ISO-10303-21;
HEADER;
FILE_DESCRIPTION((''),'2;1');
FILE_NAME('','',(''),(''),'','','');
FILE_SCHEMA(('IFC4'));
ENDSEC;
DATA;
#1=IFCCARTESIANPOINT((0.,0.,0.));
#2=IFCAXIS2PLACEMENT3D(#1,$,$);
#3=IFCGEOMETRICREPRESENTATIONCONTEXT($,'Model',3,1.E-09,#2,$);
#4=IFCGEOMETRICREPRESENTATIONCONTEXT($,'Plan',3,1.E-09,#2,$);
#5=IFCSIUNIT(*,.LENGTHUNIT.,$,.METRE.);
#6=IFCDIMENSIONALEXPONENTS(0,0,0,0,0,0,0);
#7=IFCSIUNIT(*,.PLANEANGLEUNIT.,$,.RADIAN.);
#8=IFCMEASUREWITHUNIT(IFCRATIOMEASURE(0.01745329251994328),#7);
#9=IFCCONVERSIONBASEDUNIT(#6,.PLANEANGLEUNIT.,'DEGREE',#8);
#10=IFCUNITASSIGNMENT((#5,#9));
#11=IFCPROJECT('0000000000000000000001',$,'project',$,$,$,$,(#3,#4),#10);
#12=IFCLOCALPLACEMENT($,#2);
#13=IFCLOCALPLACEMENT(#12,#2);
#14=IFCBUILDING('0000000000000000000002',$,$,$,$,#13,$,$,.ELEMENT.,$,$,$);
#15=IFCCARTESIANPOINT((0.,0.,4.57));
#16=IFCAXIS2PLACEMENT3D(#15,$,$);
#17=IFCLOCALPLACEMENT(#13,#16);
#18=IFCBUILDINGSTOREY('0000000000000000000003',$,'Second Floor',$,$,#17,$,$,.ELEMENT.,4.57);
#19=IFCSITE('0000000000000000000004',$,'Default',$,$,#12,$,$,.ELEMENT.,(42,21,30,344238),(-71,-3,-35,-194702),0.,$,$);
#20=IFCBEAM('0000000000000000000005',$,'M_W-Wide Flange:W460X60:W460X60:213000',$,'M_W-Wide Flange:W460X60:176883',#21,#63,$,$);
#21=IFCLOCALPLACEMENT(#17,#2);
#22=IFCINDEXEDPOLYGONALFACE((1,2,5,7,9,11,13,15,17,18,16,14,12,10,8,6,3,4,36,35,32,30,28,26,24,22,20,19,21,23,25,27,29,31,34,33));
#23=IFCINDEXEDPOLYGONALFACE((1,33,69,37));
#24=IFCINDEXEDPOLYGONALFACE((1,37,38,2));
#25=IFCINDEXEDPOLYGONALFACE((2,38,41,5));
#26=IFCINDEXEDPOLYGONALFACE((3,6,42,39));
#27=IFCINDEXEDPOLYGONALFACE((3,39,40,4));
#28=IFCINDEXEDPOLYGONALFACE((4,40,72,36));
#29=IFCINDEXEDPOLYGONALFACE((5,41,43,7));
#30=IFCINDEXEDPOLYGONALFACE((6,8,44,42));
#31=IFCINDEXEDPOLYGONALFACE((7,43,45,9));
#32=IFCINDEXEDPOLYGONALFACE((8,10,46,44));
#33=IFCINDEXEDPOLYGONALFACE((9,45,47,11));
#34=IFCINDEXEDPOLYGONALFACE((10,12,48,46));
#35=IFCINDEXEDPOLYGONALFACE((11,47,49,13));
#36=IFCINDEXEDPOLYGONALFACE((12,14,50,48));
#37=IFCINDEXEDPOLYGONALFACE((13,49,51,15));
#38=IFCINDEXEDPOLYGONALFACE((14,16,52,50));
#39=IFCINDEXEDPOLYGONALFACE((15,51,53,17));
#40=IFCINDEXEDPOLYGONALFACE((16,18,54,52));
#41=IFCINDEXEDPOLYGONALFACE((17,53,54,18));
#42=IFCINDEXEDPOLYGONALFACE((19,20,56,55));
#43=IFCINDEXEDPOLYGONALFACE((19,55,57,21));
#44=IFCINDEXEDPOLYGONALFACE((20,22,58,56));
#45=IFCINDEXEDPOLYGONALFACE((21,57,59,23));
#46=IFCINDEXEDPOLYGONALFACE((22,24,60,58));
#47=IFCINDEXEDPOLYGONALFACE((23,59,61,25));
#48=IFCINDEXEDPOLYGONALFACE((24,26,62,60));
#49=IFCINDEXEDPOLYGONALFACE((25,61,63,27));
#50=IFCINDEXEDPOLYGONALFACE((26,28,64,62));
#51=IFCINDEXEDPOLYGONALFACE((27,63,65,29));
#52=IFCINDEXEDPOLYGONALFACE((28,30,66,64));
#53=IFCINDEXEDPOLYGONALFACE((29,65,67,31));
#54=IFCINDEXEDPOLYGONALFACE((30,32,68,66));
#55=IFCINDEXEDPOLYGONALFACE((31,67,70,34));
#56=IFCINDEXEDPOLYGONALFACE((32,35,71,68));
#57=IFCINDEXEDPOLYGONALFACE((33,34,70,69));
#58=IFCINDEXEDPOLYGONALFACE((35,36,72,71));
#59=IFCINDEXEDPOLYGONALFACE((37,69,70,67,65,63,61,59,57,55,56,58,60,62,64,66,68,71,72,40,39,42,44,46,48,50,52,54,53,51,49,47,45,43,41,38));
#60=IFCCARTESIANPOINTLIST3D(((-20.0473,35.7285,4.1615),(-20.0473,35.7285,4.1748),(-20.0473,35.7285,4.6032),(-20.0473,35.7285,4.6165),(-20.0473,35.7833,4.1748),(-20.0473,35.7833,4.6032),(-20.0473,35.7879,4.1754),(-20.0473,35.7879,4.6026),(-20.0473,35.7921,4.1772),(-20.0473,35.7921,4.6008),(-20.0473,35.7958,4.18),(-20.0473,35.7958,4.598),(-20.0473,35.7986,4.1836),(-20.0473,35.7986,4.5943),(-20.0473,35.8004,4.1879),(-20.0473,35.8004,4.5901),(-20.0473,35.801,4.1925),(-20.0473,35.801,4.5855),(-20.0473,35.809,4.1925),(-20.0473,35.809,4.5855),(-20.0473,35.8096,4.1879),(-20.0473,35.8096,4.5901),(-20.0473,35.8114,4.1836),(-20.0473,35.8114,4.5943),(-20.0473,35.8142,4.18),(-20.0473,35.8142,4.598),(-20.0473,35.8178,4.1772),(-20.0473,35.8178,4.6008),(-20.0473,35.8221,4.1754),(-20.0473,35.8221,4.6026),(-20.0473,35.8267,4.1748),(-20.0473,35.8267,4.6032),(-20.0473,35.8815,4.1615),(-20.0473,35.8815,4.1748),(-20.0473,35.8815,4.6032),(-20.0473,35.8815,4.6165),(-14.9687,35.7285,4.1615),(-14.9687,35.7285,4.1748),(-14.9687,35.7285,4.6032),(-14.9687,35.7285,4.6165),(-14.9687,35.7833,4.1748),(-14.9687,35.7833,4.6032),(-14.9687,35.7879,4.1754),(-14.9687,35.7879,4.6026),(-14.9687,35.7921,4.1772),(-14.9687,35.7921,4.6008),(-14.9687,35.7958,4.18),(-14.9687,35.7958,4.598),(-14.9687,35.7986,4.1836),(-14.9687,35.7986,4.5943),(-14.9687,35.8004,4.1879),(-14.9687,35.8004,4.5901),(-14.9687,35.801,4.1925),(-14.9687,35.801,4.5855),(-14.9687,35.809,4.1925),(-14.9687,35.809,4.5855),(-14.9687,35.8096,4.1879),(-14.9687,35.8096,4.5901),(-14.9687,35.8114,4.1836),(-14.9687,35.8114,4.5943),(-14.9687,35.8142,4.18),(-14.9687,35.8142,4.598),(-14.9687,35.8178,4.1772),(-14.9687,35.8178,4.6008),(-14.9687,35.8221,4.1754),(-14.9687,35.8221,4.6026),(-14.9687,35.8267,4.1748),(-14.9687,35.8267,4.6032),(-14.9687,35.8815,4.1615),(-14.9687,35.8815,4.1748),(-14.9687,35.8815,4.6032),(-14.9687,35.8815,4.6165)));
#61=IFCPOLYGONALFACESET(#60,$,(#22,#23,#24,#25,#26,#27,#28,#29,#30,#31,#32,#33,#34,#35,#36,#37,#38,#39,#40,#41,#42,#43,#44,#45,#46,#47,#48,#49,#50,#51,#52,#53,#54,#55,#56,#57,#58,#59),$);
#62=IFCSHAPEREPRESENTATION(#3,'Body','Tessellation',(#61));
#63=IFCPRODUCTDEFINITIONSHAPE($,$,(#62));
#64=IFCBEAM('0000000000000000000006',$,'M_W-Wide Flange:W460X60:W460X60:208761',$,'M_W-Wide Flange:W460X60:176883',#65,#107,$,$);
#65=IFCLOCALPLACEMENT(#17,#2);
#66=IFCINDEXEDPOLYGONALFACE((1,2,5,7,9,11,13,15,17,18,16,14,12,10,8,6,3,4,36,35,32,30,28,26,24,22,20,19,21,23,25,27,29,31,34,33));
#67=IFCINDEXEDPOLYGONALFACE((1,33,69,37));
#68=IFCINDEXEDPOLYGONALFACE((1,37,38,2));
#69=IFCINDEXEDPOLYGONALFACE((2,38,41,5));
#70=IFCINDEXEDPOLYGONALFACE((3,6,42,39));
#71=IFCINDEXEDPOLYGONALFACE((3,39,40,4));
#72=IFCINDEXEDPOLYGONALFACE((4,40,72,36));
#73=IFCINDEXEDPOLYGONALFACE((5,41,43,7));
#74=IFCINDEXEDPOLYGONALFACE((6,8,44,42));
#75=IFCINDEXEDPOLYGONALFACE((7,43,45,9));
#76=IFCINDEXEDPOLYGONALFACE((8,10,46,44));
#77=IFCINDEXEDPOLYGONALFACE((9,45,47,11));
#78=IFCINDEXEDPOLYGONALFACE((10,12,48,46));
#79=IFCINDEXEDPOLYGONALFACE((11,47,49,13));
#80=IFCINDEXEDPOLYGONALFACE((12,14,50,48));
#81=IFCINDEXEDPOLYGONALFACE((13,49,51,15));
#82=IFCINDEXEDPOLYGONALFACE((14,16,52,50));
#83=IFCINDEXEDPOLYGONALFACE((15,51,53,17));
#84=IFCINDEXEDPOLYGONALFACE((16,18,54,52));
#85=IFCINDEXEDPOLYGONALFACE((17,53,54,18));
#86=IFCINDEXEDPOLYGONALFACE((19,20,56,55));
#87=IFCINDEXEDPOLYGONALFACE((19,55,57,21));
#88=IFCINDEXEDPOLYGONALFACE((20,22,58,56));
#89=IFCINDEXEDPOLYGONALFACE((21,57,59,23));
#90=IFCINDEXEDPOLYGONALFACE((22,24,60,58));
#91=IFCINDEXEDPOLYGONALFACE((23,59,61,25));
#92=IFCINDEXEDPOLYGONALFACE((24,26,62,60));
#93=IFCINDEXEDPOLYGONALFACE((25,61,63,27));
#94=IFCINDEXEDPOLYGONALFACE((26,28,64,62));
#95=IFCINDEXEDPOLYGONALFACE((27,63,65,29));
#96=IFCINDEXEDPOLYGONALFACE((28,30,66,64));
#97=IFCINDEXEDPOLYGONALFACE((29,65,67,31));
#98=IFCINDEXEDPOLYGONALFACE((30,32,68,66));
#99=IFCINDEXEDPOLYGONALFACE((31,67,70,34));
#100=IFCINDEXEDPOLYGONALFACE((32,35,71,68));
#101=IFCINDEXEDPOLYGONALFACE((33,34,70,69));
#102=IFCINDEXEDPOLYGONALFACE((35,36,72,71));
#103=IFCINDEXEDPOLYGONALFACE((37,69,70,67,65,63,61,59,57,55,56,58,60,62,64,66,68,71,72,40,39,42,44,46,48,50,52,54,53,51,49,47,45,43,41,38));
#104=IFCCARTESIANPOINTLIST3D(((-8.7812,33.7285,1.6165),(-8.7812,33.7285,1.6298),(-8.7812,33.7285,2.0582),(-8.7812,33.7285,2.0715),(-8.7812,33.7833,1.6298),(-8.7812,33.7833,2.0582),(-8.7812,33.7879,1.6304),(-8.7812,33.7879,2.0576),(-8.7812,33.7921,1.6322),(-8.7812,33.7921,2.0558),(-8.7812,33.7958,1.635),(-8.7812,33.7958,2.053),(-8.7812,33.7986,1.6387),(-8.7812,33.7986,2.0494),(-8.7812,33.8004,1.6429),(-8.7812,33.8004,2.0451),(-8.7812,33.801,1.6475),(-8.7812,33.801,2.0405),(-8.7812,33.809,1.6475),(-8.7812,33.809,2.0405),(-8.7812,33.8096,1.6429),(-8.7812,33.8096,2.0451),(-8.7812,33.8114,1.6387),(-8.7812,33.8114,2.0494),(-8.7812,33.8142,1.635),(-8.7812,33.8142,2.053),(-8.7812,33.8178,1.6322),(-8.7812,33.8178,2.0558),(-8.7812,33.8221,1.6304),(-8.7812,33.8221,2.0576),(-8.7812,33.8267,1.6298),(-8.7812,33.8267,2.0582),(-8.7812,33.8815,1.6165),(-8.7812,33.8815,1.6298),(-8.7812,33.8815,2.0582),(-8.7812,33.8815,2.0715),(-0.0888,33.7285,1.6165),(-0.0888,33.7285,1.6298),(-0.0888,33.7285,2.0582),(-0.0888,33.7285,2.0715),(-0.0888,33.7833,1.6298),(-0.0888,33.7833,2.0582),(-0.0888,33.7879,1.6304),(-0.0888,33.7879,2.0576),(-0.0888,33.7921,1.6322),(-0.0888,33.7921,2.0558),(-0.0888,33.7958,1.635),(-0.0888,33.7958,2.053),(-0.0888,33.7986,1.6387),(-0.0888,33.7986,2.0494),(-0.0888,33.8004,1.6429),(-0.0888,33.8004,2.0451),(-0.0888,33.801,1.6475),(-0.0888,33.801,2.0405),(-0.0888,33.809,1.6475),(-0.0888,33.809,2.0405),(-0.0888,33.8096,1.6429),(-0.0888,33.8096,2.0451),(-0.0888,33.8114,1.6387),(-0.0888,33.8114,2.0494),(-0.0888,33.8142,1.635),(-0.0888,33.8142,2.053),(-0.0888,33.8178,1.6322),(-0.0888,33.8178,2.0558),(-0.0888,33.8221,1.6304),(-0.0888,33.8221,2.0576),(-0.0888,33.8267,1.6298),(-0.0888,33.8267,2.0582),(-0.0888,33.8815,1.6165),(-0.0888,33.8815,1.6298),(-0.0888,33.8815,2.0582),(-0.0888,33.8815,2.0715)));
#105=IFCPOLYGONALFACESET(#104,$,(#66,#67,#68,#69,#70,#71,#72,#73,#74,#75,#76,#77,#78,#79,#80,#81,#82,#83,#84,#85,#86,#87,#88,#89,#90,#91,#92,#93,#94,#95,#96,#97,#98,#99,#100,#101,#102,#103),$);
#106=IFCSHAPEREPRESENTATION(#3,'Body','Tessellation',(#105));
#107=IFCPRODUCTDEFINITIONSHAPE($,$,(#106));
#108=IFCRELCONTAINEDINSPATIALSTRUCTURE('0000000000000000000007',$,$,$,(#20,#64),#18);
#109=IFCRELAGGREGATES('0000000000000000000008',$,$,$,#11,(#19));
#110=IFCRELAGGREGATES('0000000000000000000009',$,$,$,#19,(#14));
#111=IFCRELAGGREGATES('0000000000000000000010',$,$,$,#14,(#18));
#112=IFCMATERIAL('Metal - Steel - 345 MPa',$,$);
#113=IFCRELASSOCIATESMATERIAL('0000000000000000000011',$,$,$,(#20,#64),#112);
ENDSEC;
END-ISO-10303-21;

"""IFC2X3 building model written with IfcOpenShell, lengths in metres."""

from ifc_helpers import new_model, entity, si_unit, converted_unit, frame, frame_2d, origin, place, context, project, spatial, polyline, circle_curve, parameter, trimmed, segment, composite_curve, outline, extrude, material, element, save


model = new_model("IFC2X3")

# Units and contexts
model_context = context("Model", 3, precision=1e-09, world=origin())
plan_context = context("Plan", 3, precision=1e-09, world=origin())
ifc_project = project(units=[si_unit("LENGTHUNIT", "METRE"), converted_unit("PLANEANGLEUNIT", "DEGREE", entity("IfcRatioMeasure", 0.01745329251994328), si_unit("PLANEANGLEUNIT", "RADIAN"), dimensions=[0, 0, 0, 0, 0, 0, 0])], contexts=[model_context, plan_context])

# Site, building, storey
site_placement = place(None, origin())
site = spatial("IfcSite", under=ifc_project, at=site_placement, Name="Default", CompositionType="ELEMENT", RefLatitude=(42, 21, 30, 344238), RefLongitude=(-71, -3, -35, -194702), RefElevation=0.0)
building_placement = place(site_placement, origin())
building = spatial("IfcBuilding", under=site, at=building_placement, CompositionType="ELEMENT")
storey_placement = place(building_placement, frame((0.0, 0.0, 4.57)))
storey = spatial("IfcBuildingStorey", under=building, at=storey_placement, Name="Second Floor", CompositionType="ELEMENT", Elevation=4.57)

# Shared definitions
ifc_material = material(Name="Metal - Steel - 345 MPa")

# Beams
beam_1_placement = place(storey_placement, frame((-7.2776, 35.805, 4.6165), z_axis=(0.0, 0.0, 1.0), x_axis=(0.0, -1.0, 0.0)))
element("IfcBeam", 1, at=beam_1_placement, inside=storey, material=ifc_material, Name="M_W-Wide Flange:W460X60:W460X60:213000", ObjectType="M_W-Wide Flange:W460X60:176883", context=model_context, shape_type="SweptSolid", body=[
    extrude(outline(composite_curve([segment(polyline([(-0.0765, -0.2142), (-0.0765, -0.2275)]), True, "CONTINUOUS"), segment(polyline([(-0.0765, -0.2275), (0.0765, -0.2275)]), True, "CONTINUOUS"), segment(polyline([(0.0765, -0.2275), (0.0765, -0.2142)]), True, "CONTINUOUS"), segment(polyline([(0.0765, -0.2142), (0.0217, -0.2142)]), True, "CONTINUOUS"), segment(trimmed(circle_curve(frame_2d((0.0217, -0.1965), x_axis=(1.0, 0.0)), 0.0177), [parameter(180.0)], [parameter(270.0)], True, "PARAMETER"), False, "CONTINUOUS"), segment(polyline([(0.004, -0.1965), (0.004, 0.1965)]), True, "CONTINUOUS"), segment(trimmed(circle_curve(frame_2d((0.0217, 0.1965), x_axis=(1.0, 0.0)), 0.0177), [parameter(90.0)], [parameter(180.0)], True, "PARAMETER"), False, "CONTINUOUS"), segment(polyline([(0.0217, 0.2142), (0.0765, 0.2142)]), True, "CONTINUOUS"), segment(polyline([(0.0765, 0.2142), (0.0765, 0.2275)]), True, "CONTINUOUS"), segment(polyline([(0.0765, 0.2275), (-0.0765, 0.2275)]), True, "CONTINUOUS"), segment(polyline([(-0.0765, 0.2275), (-0.0765, 0.2142)]), True, "CONTINUOUS"), segment(polyline([(-0.0765, 0.2142), (-0.0217, 0.2142)]), True, "CONTINUOUS"), segment(trimmed(circle_curve(frame_2d((-0.0217, 0.1965), x_axis=(1.0, 0.0)), 0.0177), [parameter(360.0)], [parameter(90.0)], True, "PARAMETER"), False, "CONTINUOUS"), segment(polyline([(-0.004, 0.1965), (-0.004, -0.1965)]), True, "CONTINUOUS"), segment(trimmed(circle_curve(frame_2d((-0.0217, -0.1965), x_axis=(1.0, 0.0)), 0.0177), [parameter(270.0)], [parameter(0.0)], True, "PARAMETER"), False, "CONTINUOUS"), segment(polyline([(-0.0217, -0.2142), (-0.0765, -0.2142)]), True, "CONTINUOUS")], self_intersect=False)), frame((0.0, -12.7697, -0.2275), z_axis=(0.0, -1.0, 0.0), x_axis=(1.0, 0.0, 0.0)), (0.0, 0.0, -1.0), 5.0786),
])
beam_2_placement = place(storey_placement, frame((-7.2774, 33.805, 2.0715), z_axis=(0.0, 0.0, 1.0), x_axis=(0.0, -1.0, 0.0)))
element("IfcBeam", 2, at=beam_2_placement, inside=storey, material=ifc_material, Name="M_W-Wide Flange:W460X60:W460X60:208761", ObjectType="M_W-Wide Flange:W460X60:176883", context=model_context, shape_type="SweptSolid", body=[
    extrude(outline(composite_curve([segment(polyline([(-0.0765, -0.2142), (-0.0765, -0.2275)]), True, "CONTINUOUS"), segment(polyline([(-0.0765, -0.2275), (0.0765, -0.2275)]), True, "CONTINUOUS"), segment(polyline([(0.0765, -0.2275), (0.0765, -0.2142)]), True, "CONTINUOUS"), segment(polyline([(0.0765, -0.2142), (0.0217, -0.2142)]), True, "CONTINUOUS"), segment(trimmed(circle_curve(frame_2d((0.0217, -0.1965), x_axis=(1.0, 0.0)), 0.0177), [parameter(180.0)], [parameter(270.0)], True, "PARAMETER"), False, "CONTINUOUS"), segment(polyline([(0.004, -0.1965), (0.004, 0.1965)]), True, "CONTINUOUS"), segment(trimmed(circle_curve(frame_2d((0.0217, 0.1965), x_axis=(1.0, 0.0)), 0.0177), [parameter(90.0)], [parameter(180.0)], True, "PARAMETER"), False, "CONTINUOUS"), segment(polyline([(0.0217, 0.2142), (0.0765, 0.2142)]), True, "CONTINUOUS"), segment(polyline([(0.0765, 0.2142), (0.0765, 0.2275)]), True, "CONTINUOUS"), segment(polyline([(0.0765, 0.2275), (-0.0765, 0.2275)]), True, "CONTINUOUS"), segment(polyline([(-0.0765, 0.2275), (-0.0765, 0.2142)]), True, "CONTINUOUS"), segment(polyline([(-0.0765, 0.2142), (-0.0217, 0.2142)]), True, "CONTINUOUS"), segment(trimmed(circle_curve(frame_2d((-0.0217, 0.1965), x_axis=(1.0, 0.0)), 0.0177), [parameter(360.0)], [parameter(90.0)], True, "PARAMETER"), False, "CONTINUOUS"), segment(polyline([(-0.004, 0.1965), (-0.004, -0.1965)]), True, "CONTINUOUS"), segment(trimmed(circle_curve(frame_2d((-0.0217, -0.1965), x_axis=(1.0, 0.0)), 0.0177), [parameter(270.0)], [parameter(0.0)], True, "PARAMETER"), False, "CONTINUOUS"), segment(polyline([(-0.0217, -0.2142), (-0.0765, -0.2142)]), True, "CONTINUOUS")], self_intersect=False)), frame((0.0, -1.5038, -0.2275), z_axis=(0.0, -1.0, 0.0), x_axis=(1.0, 0.0, 0.0)), (0.0, 0.0, -1.0), 8.6924),
])

save(model, "model.ifc")
